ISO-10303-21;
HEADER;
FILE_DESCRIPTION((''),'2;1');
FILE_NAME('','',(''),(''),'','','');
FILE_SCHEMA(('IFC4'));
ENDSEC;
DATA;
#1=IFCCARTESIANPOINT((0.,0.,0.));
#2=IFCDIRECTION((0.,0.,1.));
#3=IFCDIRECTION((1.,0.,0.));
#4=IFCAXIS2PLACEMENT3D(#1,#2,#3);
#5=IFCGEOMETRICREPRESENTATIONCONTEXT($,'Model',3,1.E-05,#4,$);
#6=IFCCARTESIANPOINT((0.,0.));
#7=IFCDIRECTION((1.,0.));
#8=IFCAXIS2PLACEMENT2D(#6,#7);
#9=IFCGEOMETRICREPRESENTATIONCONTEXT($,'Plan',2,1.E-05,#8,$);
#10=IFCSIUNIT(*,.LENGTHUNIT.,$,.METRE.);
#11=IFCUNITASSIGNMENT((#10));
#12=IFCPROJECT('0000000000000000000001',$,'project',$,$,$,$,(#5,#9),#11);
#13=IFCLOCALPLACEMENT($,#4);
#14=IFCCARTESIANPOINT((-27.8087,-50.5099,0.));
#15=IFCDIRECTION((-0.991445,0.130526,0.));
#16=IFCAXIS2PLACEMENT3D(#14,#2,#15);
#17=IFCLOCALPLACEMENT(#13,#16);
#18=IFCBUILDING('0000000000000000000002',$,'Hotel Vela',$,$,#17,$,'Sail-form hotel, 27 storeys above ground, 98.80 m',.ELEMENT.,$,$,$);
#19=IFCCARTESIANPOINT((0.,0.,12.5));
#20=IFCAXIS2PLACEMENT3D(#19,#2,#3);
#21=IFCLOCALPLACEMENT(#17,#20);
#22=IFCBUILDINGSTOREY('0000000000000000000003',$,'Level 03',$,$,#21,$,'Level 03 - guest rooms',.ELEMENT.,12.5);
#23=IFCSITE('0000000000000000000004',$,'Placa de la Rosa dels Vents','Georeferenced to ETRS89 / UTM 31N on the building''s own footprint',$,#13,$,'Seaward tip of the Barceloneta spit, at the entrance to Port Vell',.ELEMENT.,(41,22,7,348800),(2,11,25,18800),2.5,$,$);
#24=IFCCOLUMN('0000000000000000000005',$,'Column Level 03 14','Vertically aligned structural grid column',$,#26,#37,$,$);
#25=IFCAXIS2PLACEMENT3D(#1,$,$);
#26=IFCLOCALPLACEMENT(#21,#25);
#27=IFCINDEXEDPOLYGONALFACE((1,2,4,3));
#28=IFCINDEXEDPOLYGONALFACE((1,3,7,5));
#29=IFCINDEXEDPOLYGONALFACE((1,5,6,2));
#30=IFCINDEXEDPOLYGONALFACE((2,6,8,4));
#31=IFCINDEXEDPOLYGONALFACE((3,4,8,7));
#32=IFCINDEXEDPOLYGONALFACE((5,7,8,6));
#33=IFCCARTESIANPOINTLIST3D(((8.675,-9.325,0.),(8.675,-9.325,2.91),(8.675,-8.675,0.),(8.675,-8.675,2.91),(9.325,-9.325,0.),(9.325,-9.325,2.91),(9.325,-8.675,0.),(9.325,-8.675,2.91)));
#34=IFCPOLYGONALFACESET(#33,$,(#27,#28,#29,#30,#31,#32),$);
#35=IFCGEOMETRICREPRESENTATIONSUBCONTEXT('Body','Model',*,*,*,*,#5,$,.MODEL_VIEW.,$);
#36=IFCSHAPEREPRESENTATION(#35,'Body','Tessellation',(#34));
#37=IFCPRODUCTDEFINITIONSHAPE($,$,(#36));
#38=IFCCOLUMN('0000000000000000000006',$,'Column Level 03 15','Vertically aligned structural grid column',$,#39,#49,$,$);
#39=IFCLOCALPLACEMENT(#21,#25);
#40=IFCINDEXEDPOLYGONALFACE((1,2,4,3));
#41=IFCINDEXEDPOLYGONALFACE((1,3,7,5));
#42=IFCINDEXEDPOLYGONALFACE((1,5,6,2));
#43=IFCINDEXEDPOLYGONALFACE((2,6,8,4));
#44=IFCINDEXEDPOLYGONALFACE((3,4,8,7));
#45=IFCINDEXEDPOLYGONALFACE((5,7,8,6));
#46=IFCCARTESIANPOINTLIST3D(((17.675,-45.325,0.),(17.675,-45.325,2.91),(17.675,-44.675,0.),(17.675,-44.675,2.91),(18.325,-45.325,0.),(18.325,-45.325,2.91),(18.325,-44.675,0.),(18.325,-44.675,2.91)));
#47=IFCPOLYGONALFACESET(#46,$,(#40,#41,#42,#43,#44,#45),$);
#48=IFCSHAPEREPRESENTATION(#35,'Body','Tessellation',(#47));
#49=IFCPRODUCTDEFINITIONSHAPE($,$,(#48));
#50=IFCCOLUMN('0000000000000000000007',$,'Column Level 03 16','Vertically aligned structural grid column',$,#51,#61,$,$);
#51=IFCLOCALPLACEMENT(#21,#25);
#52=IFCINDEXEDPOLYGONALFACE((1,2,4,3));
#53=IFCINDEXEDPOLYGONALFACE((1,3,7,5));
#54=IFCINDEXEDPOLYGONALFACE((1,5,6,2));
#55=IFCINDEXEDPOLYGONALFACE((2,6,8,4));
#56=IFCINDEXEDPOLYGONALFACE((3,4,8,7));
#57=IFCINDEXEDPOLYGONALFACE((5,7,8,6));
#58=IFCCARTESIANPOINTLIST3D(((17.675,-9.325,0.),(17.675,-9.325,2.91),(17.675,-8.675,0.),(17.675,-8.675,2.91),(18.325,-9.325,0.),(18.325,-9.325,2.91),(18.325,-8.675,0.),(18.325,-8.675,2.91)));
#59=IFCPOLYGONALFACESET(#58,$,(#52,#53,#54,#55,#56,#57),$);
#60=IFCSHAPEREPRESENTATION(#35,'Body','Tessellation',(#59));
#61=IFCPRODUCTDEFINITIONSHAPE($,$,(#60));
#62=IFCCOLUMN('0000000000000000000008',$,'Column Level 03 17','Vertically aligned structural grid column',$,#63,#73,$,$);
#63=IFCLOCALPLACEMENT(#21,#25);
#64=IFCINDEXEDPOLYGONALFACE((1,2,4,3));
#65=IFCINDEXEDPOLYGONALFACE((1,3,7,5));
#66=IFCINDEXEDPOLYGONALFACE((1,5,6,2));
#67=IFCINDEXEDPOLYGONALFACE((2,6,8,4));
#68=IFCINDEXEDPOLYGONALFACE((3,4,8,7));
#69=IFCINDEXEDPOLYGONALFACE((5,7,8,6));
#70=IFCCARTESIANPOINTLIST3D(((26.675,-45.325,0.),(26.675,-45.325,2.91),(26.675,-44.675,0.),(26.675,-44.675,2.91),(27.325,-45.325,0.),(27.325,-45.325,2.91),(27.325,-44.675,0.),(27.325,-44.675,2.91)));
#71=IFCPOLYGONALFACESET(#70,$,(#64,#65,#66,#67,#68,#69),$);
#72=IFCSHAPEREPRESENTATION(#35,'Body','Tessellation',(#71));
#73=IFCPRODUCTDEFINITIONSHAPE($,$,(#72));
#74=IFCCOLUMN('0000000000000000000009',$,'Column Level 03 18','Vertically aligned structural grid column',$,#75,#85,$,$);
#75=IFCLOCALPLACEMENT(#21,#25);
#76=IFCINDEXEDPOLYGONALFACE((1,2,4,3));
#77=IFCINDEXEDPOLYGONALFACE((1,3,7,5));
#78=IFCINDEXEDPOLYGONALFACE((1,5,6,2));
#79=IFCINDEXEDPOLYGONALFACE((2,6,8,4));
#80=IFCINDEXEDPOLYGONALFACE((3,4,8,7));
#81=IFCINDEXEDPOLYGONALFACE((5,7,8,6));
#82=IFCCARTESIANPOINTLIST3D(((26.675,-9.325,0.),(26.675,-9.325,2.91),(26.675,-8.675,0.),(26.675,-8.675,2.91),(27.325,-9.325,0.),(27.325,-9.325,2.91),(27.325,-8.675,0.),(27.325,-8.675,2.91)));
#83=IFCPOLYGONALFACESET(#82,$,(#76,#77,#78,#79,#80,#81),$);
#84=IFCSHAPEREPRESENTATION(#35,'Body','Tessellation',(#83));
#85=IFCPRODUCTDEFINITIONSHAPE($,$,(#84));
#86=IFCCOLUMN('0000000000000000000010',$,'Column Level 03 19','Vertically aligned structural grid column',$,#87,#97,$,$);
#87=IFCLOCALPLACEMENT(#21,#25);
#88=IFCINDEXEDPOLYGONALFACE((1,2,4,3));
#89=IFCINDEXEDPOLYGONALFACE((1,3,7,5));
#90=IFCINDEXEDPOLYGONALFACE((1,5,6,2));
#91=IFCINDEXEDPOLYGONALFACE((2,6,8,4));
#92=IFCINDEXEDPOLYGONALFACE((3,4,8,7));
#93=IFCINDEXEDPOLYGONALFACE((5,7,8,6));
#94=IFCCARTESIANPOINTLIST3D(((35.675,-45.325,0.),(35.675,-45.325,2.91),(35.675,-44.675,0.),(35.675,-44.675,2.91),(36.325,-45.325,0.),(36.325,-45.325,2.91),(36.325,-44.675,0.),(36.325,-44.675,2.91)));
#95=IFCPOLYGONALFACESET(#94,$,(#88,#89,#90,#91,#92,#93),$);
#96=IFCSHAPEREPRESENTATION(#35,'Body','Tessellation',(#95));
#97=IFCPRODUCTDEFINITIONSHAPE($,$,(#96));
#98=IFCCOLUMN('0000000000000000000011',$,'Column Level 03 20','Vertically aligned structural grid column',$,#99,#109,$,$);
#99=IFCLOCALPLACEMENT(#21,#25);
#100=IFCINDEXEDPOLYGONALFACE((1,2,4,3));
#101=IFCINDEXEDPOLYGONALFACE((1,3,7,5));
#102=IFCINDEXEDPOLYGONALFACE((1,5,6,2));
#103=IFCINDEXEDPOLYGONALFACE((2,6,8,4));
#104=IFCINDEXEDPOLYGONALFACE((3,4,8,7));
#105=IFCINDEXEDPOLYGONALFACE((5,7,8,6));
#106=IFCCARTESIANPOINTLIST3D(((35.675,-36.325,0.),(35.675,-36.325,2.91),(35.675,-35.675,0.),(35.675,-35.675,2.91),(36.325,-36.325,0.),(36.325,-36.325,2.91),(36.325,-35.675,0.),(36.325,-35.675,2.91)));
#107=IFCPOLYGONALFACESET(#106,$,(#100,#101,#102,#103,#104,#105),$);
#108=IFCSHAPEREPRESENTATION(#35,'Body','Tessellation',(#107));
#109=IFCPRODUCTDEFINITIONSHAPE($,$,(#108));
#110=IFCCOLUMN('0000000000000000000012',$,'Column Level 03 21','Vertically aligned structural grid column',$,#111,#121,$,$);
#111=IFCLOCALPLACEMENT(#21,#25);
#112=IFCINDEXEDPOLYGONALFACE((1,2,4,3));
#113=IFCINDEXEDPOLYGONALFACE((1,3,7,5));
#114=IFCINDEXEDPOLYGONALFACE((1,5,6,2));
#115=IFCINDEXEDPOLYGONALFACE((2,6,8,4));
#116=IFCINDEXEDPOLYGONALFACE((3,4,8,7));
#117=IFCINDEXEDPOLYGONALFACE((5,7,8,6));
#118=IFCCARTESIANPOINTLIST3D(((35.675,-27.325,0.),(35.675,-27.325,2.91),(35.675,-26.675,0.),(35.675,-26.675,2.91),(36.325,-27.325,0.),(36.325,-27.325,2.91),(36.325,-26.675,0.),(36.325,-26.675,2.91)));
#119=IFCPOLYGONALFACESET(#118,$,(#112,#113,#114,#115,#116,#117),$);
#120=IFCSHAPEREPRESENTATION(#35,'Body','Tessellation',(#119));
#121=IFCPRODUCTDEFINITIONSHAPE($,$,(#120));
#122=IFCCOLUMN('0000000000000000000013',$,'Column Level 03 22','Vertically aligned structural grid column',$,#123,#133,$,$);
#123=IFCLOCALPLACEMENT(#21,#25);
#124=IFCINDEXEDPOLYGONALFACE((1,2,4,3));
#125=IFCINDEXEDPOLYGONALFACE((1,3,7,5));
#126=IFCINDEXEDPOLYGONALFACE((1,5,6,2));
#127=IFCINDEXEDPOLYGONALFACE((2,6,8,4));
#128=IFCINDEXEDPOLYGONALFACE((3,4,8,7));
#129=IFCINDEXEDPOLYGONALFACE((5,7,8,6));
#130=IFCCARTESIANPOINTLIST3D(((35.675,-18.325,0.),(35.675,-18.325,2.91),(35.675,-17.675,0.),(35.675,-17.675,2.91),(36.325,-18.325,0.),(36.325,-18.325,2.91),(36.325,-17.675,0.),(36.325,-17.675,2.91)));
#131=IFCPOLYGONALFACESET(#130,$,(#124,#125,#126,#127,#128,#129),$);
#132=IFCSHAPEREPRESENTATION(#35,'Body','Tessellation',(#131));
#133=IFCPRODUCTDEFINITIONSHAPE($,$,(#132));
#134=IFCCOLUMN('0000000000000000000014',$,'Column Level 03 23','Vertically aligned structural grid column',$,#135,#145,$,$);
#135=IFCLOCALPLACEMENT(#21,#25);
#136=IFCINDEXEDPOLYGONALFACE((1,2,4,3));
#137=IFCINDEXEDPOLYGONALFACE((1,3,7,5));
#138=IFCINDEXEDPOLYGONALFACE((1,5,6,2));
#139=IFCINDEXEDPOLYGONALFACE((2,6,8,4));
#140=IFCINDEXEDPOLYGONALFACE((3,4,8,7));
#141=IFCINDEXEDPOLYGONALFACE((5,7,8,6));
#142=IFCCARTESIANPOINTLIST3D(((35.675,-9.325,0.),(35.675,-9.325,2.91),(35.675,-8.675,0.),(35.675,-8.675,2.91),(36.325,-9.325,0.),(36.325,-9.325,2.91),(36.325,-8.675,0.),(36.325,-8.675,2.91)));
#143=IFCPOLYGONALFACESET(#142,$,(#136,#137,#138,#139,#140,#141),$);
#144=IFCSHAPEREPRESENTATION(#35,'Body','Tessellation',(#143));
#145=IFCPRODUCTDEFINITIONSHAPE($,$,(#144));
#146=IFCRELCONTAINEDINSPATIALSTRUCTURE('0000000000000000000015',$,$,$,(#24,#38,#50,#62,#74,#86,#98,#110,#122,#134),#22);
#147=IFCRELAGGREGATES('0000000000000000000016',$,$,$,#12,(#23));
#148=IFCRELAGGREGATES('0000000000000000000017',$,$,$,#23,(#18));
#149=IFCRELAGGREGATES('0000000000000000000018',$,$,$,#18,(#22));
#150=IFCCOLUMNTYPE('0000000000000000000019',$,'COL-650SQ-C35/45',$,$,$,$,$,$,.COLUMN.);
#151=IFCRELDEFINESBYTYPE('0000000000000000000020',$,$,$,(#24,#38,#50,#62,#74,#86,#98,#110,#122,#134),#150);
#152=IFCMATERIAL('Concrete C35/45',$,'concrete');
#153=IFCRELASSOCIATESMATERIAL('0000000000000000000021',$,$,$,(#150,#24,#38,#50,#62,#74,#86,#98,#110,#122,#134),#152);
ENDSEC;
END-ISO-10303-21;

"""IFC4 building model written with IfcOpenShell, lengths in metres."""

from ifc_helpers import new_model, si_unit, frame, origin_with_axes, origin_2d_with_axis, place, context, subcontext, project, spatial, line, indexed_curve, rectangle, outline, extrude, material, material_profile, profile_set, profile_usage, type_object, element, save


model = new_model("IFC4")

# Units and contexts
model_context = context("Model", 3, precision=1e-05, world=origin_with_axes())
plan_context = context("Plan", 2, precision=1e-05, world=origin_2d_with_axis())
body_context = subcontext(model_context, "Body", "Model", "MODEL_VIEW")
ifc_project = project(units=[si_unit("LENGTHUNIT", "METRE")], contexts=[model_context, plan_context])

# Site, building, storey
site_placement = place(None, origin_with_axes())
site = spatial("IfcSite", under=ifc_project, at=site_placement, Name="Placa de la Rosa dels Vents", Description="Georeferenced to ETRS89 / UTM 31N on the building's own footprint", LongName="Seaward tip of the Barceloneta spit, at the entrance to Port Vell", CompositionType="ELEMENT", RefLatitude=(41, 22, 7, 348800), RefLongitude=(2, 11, 25, 18800), RefElevation=2.5)
building_placement = place(site_placement, frame((-27.8087, -50.5099, 0.0), z_axis=(0.0, 0.0, 1.0), x_axis=(-0.991445, 0.130526, 0.0)))
building = spatial("IfcBuilding", under=site, at=building_placement, Name="Hotel Vela", LongName="Sail-form hotel, 27 storeys above ground, 98.80 m", CompositionType="ELEMENT")
storey_placement = place(building_placement, frame((0.0, 0.0, 12.5), z_axis=(0.0, 0.0, 1.0), x_axis=(1.0, 0.0, 0.0)))
storey = spatial("IfcBuildingStorey", under=building, at=storey_placement, Name="Level 03", LongName="Level 03 - guest rooms", CompositionType="ELEMENT", Elevation=12.5)

# Columns
ifc_material = material(Name="Concrete C35/45", Category="concrete")
ifc_material_profile = material_profile(ifc_material, rectangle(XDim=0.65, YDim=0.65))
ifc_profile_set = profile_set([ifc_material_profile], Name="COL-650SQ-C35/45")
column_type = type_object("IfcColumnType", Name="COL-650SQ-C35/45", PredefinedType="COLUMN", material=ifc_profile_set)
ifc_profile_usage_1 = profile_usage(ifc_profile_set)
column_1_placement = place(storey_placement, frame((8.675, -9.325, 0.0), z_axis=(0.0, 0.0, 1.0), x_axis=(1.0, 0.0, 0.0)))
element("IfcColumn", 1, at=column_1_placement, inside=storey, type_object=column_type, material=ifc_profile_usage_1, Name="Column Level 03 14", Description="Vertically aligned structural grid column", context=body_context, shape_type="SweptSolid", body=[
    extrude(outline(indexed_curve([(0.0, 0.0), (0.65, 0.0), (0.65, 0.65), (0.0, 0.65)], segments=[line(1, 2, 3, 4, 1)])), origin_with_axes(), (0.0, 0.0, 1.0), 2.91),
])
ifc_profile_usage_2 = profile_usage(ifc_profile_set)
column_2_placement = place(storey_placement, frame((17.675, -45.325, 0.0), z_axis=(0.0, 0.0, 1.0), x_axis=(1.0, 0.0, 0.0)))
element("IfcColumn", 2, at=column_2_placement, inside=storey, type_object=column_type, material=ifc_profile_usage_2, Name="Column Level 03 15", Description="Vertically aligned structural grid column", context=body_context, shape_type="SweptSolid", body=[
    extrude(outline(indexed_curve([(0.0, 0.0), (0.65, 0.0), (0.65, 0.65), (0.0, 0.65)], segments=[line(1, 2, 3, 4, 1)])), origin_with_axes(), (0.0, 0.0, 1.0), 2.91),
])
ifc_profile_usage_3 = profile_usage(ifc_profile_set)
column_3_placement = place(storey_placement, frame((17.675, -9.325, 0.0), z_axis=(0.0, 0.0, 1.0), x_axis=(1.0, 0.0, 0.0)))
element("IfcColumn", 3, at=column_3_placement, inside=storey, type_object=column_type, material=ifc_profile_usage_3, Name="Column Level 03 16", Description="Vertically aligned structural grid column", context=body_context, shape_type="SweptSolid", body=[
    extrude(outline(indexed_curve([(0.0, 0.0), (0.65, 0.0), (0.65, 0.65), (0.0, 0.65)], segments=[line(1, 2, 3, 4, 1)])), origin_with_axes(), (0.0, 0.0, 1.0), 2.91),
])
ifc_profile_usage_4 = profile_usage(ifc_profile_set)
column_4_placement = place(storey_placement, frame((26.675, -45.325, 0.0), z_axis=(0.0, 0.0, 1.0), x_axis=(1.0, 0.0, 0.0)))
element("IfcColumn", 4, at=column_4_placement, inside=storey, type_object=column_type, material=ifc_profile_usage_4, Name="Column Level 03 17", Description="Vertically aligned structural grid column", context=body_context, shape_type="SweptSolid", body=[
    extrude(outline(indexed_curve([(0.0, 0.0), (0.65, 0.0), (0.65, 0.65), (0.0, 0.65)], segments=[line(1, 2, 3, 4, 1)])), origin_with_axes(), (0.0, 0.0, 1.0), 2.91),
])
ifc_profile_usage_5 = profile_usage(ifc_profile_set)
column_5_placement = place(storey_placement, frame((26.675, -9.325, 0.0), z_axis=(0.0, 0.0, 1.0), x_axis=(1.0, 0.0, 0.0)))
element("IfcColumn", 5, at=column_5_placement, inside=storey, type_object=column_type, material=ifc_profile_usage_5, Name="Column Level 03 18", Description="Vertically aligned structural grid column", context=body_context, shape_type="SweptSolid", body=[
    extrude(outline(indexed_curve([(0.0, 0.0), (0.65, 0.0), (0.65, 0.65), (0.0, 0.65)], segments=[line(1, 2, 3, 4, 1)])), origin_with_axes(), (0.0, 0.0, 1.0), 2.91),
])
ifc_profile_usage_6 = profile_usage(ifc_profile_set)
column_6_placement = place(storey_placement, frame((35.675, -45.325, 0.0), z_axis=(0.0, 0.0, 1.0), x_axis=(1.0, 0.0, 0.0)))
element("IfcColumn", 6, at=column_6_placement, inside=storey, type_object=column_type, material=ifc_profile_usage_6, Name="Column Level 03 19", Description="Vertically aligned structural grid column", context=body_context, shape_type="SweptSolid", body=[
    extrude(outline(indexed_curve([(0.0, 0.0), (0.65, 0.0), (0.65, 0.65), (0.0, 0.65)], segments=[line(1, 2, 3, 4, 1)])), origin_with_axes(), (0.0, 0.0, 1.0), 2.91),
])
ifc_profile_usage_7 = profile_usage(ifc_profile_set)
column_7_placement = place(storey_placement, frame((35.675, -36.325, 0.0), z_axis=(0.0, 0.0, 1.0), x_axis=(1.0, 0.0, 0.0)))
element("IfcColumn", 7, at=column_7_placement, inside=storey, type_object=column_type, material=ifc_profile_usage_7, Name="Column Level 03 20", Description="Vertically aligned structural grid column", context=body_context, shape_type="SweptSolid", body=[
    extrude(outline(indexed_curve([(0.0, 0.0), (0.65, 0.0), (0.65, 0.65), (0.0, 0.65)], segments=[line(1, 2, 3, 4, 1)])), origin_with_axes(), (0.0, 0.0, 1.0), 2.91),
])
ifc_profile_usage_8 = profile_usage(ifc_profile_set)
column_8_placement = place(storey_placement, frame((35.675, -27.325, 0.0), z_axis=(0.0, 0.0, 1.0), x_axis=(1.0, 0.0, 0.0)))
element("IfcColumn", 8, at=column_8_placement, inside=storey, type_object=column_type, material=ifc_profile_usage_8, Name="Column Level 03 21", Description="Vertically aligned structural grid column", context=body_context, shape_type="SweptSolid", body=[
    extrude(outline(indexed_curve([(0.0, 0.0), (0.65, 0.0), (0.65, 0.65), (0.0, 0.65)], segments=[line(1, 2, 3, 4, 1)])), origin_with_axes(), (0.0, 0.0, 1.0), 2.91),
])
ifc_profile_usage_9 = profile_usage(ifc_profile_set)
column_9_placement = place(storey_placement, frame((35.675, -18.325, 0.0), z_axis=(0.0, 0.0, 1.0), x_axis=(1.0, 0.0, 0.0)))
element("IfcColumn", 9, at=column_9_placement, inside=storey, type_object=column_type, material=ifc_profile_usage_9, Name="Column Level 03 22", Description="Vertically aligned structural grid column", context=body_context, shape_type="SweptSolid", body=[
    extrude(outline(indexed_curve([(0.0, 0.0), (0.65, 0.0), (0.65, 0.65), (0.0, 0.65)], segments=[line(1, 2, 3, 4, 1)])), origin_with_axes(), (0.0, 0.0, 1.0), 2.91),
])
ifc_profile_usage_10 = profile_usage(ifc_profile_set)
column_10_placement = place(storey_placement, frame((35.675, -9.325, 0.0), z_axis=(0.0, 0.0, 1.0), x_axis=(1.0, 0.0, 0.0)))
element("IfcColumn", 10, at=column_10_placement, inside=storey, type_object=column_type, material=ifc_profile_usage_10, Name="Column Level 03 23", Description="Vertically aligned structural grid column", context=body_context, shape_type="SweptSolid", body=[
    extrude(outline(indexed_curve([(0.0, 0.0), (0.65, 0.0), (0.65, 0.65), (0.0, 0.65)], segments=[line(1, 2, 3, 4, 1)])), origin_with_axes(), (0.0, 0.0, 1.0), 2.91),
])

save(model, "model.ifc")
